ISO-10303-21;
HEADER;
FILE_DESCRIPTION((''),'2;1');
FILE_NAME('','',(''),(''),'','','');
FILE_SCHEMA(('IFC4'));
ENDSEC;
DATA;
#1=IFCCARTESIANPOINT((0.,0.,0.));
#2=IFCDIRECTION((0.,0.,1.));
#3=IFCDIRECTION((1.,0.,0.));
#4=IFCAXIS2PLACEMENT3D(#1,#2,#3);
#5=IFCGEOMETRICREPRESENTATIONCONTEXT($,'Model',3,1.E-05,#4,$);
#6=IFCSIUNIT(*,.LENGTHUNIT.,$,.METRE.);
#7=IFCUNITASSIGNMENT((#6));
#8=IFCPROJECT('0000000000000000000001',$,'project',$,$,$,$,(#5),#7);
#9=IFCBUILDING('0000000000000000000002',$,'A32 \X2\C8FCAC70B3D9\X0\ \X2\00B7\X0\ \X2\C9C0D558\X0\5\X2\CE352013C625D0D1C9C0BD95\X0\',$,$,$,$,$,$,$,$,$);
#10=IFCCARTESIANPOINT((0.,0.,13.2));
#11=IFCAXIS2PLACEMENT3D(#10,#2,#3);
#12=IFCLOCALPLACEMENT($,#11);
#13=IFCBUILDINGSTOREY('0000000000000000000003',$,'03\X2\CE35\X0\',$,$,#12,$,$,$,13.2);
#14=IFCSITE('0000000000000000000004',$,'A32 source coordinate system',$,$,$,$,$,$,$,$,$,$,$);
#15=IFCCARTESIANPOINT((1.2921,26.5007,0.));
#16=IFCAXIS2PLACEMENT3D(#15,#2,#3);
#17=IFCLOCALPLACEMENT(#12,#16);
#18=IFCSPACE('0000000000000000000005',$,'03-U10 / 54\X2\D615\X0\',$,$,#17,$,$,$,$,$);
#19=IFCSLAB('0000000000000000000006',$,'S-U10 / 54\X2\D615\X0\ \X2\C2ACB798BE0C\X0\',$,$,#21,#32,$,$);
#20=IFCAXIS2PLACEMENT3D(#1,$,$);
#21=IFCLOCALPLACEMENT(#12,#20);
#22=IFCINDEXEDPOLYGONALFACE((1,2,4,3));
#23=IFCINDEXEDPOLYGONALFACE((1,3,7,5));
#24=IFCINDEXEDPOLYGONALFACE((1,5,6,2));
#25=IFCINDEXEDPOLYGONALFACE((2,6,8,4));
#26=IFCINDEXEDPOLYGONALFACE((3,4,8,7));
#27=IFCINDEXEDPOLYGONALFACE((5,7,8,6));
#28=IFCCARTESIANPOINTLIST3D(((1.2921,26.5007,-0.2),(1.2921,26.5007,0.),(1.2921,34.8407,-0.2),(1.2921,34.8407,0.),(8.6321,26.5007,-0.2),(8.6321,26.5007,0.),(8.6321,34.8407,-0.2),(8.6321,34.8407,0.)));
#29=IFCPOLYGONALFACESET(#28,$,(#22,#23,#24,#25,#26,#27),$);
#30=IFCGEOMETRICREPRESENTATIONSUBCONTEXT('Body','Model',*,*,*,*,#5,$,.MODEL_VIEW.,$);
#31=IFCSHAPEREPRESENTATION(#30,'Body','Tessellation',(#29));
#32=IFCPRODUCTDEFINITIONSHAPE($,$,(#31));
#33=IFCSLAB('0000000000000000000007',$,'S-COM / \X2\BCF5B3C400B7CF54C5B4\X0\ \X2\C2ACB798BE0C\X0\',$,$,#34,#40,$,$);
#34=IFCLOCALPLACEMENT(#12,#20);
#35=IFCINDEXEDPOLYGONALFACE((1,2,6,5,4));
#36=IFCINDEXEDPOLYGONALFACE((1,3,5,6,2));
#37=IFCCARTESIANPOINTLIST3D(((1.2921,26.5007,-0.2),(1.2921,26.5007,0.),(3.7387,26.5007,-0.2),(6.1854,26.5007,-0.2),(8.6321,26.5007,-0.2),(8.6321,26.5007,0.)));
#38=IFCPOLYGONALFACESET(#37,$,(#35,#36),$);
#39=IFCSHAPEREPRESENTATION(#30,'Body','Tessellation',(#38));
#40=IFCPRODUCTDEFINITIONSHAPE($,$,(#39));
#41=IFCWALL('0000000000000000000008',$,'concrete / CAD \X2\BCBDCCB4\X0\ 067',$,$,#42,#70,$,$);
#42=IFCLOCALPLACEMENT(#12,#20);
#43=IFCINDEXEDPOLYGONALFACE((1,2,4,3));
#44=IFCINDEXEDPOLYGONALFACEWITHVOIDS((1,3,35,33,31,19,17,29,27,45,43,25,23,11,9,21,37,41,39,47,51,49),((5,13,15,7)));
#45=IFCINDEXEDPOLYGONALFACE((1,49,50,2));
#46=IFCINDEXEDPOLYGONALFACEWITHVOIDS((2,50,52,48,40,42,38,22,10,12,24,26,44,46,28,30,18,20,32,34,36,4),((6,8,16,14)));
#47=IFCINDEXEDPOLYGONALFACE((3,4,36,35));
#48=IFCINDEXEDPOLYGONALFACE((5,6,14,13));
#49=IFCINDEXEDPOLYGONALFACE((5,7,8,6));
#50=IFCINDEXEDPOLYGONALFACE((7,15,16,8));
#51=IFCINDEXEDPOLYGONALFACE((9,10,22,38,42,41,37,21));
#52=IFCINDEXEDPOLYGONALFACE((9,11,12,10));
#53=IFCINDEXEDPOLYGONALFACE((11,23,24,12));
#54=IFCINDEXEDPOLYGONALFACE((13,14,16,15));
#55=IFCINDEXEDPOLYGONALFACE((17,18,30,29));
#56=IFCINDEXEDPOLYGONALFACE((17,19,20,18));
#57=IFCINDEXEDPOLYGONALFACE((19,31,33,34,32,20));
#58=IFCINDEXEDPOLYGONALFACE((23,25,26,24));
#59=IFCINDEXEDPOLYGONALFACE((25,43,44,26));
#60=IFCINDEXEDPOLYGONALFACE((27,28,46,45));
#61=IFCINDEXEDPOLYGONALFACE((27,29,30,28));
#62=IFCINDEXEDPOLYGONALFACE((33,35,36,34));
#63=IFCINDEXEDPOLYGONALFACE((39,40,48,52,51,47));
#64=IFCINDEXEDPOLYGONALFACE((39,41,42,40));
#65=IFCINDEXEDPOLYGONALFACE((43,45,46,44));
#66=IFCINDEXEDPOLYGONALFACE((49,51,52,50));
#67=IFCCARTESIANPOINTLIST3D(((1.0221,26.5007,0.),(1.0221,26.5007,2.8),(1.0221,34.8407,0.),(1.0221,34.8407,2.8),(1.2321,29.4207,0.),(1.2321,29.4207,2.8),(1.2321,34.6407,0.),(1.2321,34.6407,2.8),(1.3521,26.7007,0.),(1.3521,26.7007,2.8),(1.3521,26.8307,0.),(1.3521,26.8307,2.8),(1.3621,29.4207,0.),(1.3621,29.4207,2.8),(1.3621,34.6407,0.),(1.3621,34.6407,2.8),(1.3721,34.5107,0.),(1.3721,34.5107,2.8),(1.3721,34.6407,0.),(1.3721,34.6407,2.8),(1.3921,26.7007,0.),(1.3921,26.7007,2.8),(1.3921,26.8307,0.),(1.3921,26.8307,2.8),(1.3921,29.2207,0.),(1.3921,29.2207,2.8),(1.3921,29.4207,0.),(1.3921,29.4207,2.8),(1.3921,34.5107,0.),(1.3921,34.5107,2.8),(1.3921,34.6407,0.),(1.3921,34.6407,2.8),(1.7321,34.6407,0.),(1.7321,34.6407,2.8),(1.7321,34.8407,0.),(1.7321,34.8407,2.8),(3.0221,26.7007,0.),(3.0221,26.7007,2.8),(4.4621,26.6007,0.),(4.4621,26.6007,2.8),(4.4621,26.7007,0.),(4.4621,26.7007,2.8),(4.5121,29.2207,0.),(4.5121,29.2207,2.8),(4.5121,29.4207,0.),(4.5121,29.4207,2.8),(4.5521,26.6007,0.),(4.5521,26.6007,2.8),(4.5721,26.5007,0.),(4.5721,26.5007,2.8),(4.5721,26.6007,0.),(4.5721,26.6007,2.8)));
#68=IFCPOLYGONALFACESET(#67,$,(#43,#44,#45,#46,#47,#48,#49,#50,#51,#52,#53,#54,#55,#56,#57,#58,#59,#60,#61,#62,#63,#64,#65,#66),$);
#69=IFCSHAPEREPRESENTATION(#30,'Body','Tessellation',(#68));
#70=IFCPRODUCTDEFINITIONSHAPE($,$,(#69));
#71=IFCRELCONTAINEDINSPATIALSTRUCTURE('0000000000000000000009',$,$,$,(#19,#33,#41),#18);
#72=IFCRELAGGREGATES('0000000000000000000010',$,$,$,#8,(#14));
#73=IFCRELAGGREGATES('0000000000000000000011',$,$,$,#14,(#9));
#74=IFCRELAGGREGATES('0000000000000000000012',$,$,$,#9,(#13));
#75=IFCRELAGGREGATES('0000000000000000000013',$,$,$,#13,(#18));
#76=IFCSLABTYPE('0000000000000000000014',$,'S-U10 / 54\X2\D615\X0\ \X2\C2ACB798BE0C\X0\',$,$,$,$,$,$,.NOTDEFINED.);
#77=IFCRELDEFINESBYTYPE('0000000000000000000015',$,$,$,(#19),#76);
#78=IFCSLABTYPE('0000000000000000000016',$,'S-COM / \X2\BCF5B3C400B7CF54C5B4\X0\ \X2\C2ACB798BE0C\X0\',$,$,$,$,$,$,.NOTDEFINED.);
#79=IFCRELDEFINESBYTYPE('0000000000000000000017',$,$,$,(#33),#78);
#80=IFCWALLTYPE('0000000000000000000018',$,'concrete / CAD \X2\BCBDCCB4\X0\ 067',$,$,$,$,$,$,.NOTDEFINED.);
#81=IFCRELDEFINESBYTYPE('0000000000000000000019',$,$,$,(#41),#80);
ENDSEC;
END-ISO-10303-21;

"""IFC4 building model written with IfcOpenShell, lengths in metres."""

from ifc_helpers import new_model, si_unit, frame, origin, origin_with_axes, place, context, subcontext, project, spatial, polyline, outline, extrude, source, transform, mapped, type_object, type_shapes, element, save


model = new_model("IFC4")

# Units and contexts
model_context = context("Model", 3, precision=1e-05, world=origin_with_axes())
body_context = subcontext(model_context, "Body", "Model", "MODEL_VIEW")
ifc_project = project(units=[si_unit("LENGTHUNIT", "METRE")], contexts=[model_context])

# Site, building, storey, space
storey_placement = place(None, frame((0.0, 0.0, 13.2), z_axis=(0.0, 0.0, 1.0), x_axis=(1.0, 0.0, 0.0)))
space_placement = place(storey_placement, frame((1.2921, 26.5007, 0.0), z_axis=(0.0, 0.0, 1.0), x_axis=(1.0, 0.0, 0.0)))
site = spatial("IfcSite", under=ifc_project, Name="A32 source coordinate system")
building = spatial("IfcBuilding", under=site, Name="A32 주거동 · 지하5층–옥탑지붕")
storey = spatial("IfcBuildingStorey", under=building, at=storey_placement, Name="03층", Elevation=13.2)
space = spatial("IfcSpace", under=storey, at=space_placement, Name="03-U10 / 54형")

# Slabs
slab_type_1 = type_object("IfcSlabType", Name="S-U10 / 54형 슬래브", PredefinedType="NOTDEFINED")
shared_shape_1 = source(origin(), body_context, "Body", "SweptSolid", [
    extrude(outline(polyline([(0.0, 0.0), (0.0, 8.34), (7.34, 8.34), (7.34, 0.0), (0.0, 0.0)])), frame((0.0, 0.0, -0.2)), (0.0, 0.0, 1.0), 0.2),
])
type_shapes(slab_type_1, [shared_shape_1])
slab_1_placement = place(space_placement, origin_with_axes())
element("IfcSlab", 1, at=slab_1_placement, inside=space, type_object=slab_type_1, Name="S-U10 / 54형 슬래브", context=body_context, shape_type="MappedRepresentation", body=[
    mapped(shared_shape_1, transform((0.0, 0.0, 0.0), scale=1.0)),
])
slab_type_2 = type_object("IfcSlabType", Name="S-COM / 복도·코어 슬래브", PredefinedType="NOTDEFINED")
shared_shape_2 = source(origin(), body_context, "Body", "SweptSolid", [
    extrude(outline(polyline([(7.34, 0.0), (7.34, 0.0), (0.0, 0.0), (0.0, 0.0), (7.34, 0.0)])), frame((0.0, 0.0, -0.2)), (0.0, 0.0, 1.0), 0.2),
])
type_shapes(slab_type_2, [shared_shape_2])
slab_2_placement = place(space_placement, origin_with_axes())
element("IfcSlab", 2, at=slab_2_placement, inside=space, type_object=slab_type_2, Name="S-COM / 복도·코어 슬래브", context=body_context, shape_type="MappedRepresentation", body=[
    mapped(shared_shape_2, transform((0.0, 0.0, 0.0), scale=1.0)),
])

# Wall
wall_type_1 = type_object("IfcWallType", Name="concrete / CAD 벽체 067", PredefinedType="NOTDEFINED")
shared_shape_3 = source(origin(), body_context, "Body", "SweptSolid", [
    extrude(outline(polyline([(0.1, 0.2), (1.73, 0.2), (3.17, 0.2), (3.17, 0.1), (3.26, 0.1), (3.28, 0.1), (3.28, 0.0), (-0.27, 0.0), (-0.27, 8.34), (0.44, 8.34), (0.44, 8.14), (0.1, 8.14), (0.08, 8.14), (0.08, 8.01), (0.1, 8.01), (0.1, 2.92), (3.22, 2.92), (3.22, 2.72), (0.1, 2.72), (0.1, 0.33), (0.06, 0.33), (0.06, 0.2), (0.1, 0.2)]), holes=[polyline([(-0.06, 8.14), (-0.06, 2.92), (0.07, 2.92), (0.07, 8.14), (-0.06, 8.14)])]), origin(), (0.0, 0.0, 1.0), 2.8),
])
type_shapes(wall_type_1, [shared_shape_3])
wall_1_placement = place(space_placement, origin_with_axes())
element("IfcWall", 3, at=wall_1_placement, inside=space, type_object=wall_type_1, Name="concrete / CAD 벽체 067", context=body_context, shape_type="MappedRepresentation", body=[
    mapped(shared_shape_3, transform((0.0, 0.0, 0.0), scale=1.0)),
])

save(model, "model.ifc")
